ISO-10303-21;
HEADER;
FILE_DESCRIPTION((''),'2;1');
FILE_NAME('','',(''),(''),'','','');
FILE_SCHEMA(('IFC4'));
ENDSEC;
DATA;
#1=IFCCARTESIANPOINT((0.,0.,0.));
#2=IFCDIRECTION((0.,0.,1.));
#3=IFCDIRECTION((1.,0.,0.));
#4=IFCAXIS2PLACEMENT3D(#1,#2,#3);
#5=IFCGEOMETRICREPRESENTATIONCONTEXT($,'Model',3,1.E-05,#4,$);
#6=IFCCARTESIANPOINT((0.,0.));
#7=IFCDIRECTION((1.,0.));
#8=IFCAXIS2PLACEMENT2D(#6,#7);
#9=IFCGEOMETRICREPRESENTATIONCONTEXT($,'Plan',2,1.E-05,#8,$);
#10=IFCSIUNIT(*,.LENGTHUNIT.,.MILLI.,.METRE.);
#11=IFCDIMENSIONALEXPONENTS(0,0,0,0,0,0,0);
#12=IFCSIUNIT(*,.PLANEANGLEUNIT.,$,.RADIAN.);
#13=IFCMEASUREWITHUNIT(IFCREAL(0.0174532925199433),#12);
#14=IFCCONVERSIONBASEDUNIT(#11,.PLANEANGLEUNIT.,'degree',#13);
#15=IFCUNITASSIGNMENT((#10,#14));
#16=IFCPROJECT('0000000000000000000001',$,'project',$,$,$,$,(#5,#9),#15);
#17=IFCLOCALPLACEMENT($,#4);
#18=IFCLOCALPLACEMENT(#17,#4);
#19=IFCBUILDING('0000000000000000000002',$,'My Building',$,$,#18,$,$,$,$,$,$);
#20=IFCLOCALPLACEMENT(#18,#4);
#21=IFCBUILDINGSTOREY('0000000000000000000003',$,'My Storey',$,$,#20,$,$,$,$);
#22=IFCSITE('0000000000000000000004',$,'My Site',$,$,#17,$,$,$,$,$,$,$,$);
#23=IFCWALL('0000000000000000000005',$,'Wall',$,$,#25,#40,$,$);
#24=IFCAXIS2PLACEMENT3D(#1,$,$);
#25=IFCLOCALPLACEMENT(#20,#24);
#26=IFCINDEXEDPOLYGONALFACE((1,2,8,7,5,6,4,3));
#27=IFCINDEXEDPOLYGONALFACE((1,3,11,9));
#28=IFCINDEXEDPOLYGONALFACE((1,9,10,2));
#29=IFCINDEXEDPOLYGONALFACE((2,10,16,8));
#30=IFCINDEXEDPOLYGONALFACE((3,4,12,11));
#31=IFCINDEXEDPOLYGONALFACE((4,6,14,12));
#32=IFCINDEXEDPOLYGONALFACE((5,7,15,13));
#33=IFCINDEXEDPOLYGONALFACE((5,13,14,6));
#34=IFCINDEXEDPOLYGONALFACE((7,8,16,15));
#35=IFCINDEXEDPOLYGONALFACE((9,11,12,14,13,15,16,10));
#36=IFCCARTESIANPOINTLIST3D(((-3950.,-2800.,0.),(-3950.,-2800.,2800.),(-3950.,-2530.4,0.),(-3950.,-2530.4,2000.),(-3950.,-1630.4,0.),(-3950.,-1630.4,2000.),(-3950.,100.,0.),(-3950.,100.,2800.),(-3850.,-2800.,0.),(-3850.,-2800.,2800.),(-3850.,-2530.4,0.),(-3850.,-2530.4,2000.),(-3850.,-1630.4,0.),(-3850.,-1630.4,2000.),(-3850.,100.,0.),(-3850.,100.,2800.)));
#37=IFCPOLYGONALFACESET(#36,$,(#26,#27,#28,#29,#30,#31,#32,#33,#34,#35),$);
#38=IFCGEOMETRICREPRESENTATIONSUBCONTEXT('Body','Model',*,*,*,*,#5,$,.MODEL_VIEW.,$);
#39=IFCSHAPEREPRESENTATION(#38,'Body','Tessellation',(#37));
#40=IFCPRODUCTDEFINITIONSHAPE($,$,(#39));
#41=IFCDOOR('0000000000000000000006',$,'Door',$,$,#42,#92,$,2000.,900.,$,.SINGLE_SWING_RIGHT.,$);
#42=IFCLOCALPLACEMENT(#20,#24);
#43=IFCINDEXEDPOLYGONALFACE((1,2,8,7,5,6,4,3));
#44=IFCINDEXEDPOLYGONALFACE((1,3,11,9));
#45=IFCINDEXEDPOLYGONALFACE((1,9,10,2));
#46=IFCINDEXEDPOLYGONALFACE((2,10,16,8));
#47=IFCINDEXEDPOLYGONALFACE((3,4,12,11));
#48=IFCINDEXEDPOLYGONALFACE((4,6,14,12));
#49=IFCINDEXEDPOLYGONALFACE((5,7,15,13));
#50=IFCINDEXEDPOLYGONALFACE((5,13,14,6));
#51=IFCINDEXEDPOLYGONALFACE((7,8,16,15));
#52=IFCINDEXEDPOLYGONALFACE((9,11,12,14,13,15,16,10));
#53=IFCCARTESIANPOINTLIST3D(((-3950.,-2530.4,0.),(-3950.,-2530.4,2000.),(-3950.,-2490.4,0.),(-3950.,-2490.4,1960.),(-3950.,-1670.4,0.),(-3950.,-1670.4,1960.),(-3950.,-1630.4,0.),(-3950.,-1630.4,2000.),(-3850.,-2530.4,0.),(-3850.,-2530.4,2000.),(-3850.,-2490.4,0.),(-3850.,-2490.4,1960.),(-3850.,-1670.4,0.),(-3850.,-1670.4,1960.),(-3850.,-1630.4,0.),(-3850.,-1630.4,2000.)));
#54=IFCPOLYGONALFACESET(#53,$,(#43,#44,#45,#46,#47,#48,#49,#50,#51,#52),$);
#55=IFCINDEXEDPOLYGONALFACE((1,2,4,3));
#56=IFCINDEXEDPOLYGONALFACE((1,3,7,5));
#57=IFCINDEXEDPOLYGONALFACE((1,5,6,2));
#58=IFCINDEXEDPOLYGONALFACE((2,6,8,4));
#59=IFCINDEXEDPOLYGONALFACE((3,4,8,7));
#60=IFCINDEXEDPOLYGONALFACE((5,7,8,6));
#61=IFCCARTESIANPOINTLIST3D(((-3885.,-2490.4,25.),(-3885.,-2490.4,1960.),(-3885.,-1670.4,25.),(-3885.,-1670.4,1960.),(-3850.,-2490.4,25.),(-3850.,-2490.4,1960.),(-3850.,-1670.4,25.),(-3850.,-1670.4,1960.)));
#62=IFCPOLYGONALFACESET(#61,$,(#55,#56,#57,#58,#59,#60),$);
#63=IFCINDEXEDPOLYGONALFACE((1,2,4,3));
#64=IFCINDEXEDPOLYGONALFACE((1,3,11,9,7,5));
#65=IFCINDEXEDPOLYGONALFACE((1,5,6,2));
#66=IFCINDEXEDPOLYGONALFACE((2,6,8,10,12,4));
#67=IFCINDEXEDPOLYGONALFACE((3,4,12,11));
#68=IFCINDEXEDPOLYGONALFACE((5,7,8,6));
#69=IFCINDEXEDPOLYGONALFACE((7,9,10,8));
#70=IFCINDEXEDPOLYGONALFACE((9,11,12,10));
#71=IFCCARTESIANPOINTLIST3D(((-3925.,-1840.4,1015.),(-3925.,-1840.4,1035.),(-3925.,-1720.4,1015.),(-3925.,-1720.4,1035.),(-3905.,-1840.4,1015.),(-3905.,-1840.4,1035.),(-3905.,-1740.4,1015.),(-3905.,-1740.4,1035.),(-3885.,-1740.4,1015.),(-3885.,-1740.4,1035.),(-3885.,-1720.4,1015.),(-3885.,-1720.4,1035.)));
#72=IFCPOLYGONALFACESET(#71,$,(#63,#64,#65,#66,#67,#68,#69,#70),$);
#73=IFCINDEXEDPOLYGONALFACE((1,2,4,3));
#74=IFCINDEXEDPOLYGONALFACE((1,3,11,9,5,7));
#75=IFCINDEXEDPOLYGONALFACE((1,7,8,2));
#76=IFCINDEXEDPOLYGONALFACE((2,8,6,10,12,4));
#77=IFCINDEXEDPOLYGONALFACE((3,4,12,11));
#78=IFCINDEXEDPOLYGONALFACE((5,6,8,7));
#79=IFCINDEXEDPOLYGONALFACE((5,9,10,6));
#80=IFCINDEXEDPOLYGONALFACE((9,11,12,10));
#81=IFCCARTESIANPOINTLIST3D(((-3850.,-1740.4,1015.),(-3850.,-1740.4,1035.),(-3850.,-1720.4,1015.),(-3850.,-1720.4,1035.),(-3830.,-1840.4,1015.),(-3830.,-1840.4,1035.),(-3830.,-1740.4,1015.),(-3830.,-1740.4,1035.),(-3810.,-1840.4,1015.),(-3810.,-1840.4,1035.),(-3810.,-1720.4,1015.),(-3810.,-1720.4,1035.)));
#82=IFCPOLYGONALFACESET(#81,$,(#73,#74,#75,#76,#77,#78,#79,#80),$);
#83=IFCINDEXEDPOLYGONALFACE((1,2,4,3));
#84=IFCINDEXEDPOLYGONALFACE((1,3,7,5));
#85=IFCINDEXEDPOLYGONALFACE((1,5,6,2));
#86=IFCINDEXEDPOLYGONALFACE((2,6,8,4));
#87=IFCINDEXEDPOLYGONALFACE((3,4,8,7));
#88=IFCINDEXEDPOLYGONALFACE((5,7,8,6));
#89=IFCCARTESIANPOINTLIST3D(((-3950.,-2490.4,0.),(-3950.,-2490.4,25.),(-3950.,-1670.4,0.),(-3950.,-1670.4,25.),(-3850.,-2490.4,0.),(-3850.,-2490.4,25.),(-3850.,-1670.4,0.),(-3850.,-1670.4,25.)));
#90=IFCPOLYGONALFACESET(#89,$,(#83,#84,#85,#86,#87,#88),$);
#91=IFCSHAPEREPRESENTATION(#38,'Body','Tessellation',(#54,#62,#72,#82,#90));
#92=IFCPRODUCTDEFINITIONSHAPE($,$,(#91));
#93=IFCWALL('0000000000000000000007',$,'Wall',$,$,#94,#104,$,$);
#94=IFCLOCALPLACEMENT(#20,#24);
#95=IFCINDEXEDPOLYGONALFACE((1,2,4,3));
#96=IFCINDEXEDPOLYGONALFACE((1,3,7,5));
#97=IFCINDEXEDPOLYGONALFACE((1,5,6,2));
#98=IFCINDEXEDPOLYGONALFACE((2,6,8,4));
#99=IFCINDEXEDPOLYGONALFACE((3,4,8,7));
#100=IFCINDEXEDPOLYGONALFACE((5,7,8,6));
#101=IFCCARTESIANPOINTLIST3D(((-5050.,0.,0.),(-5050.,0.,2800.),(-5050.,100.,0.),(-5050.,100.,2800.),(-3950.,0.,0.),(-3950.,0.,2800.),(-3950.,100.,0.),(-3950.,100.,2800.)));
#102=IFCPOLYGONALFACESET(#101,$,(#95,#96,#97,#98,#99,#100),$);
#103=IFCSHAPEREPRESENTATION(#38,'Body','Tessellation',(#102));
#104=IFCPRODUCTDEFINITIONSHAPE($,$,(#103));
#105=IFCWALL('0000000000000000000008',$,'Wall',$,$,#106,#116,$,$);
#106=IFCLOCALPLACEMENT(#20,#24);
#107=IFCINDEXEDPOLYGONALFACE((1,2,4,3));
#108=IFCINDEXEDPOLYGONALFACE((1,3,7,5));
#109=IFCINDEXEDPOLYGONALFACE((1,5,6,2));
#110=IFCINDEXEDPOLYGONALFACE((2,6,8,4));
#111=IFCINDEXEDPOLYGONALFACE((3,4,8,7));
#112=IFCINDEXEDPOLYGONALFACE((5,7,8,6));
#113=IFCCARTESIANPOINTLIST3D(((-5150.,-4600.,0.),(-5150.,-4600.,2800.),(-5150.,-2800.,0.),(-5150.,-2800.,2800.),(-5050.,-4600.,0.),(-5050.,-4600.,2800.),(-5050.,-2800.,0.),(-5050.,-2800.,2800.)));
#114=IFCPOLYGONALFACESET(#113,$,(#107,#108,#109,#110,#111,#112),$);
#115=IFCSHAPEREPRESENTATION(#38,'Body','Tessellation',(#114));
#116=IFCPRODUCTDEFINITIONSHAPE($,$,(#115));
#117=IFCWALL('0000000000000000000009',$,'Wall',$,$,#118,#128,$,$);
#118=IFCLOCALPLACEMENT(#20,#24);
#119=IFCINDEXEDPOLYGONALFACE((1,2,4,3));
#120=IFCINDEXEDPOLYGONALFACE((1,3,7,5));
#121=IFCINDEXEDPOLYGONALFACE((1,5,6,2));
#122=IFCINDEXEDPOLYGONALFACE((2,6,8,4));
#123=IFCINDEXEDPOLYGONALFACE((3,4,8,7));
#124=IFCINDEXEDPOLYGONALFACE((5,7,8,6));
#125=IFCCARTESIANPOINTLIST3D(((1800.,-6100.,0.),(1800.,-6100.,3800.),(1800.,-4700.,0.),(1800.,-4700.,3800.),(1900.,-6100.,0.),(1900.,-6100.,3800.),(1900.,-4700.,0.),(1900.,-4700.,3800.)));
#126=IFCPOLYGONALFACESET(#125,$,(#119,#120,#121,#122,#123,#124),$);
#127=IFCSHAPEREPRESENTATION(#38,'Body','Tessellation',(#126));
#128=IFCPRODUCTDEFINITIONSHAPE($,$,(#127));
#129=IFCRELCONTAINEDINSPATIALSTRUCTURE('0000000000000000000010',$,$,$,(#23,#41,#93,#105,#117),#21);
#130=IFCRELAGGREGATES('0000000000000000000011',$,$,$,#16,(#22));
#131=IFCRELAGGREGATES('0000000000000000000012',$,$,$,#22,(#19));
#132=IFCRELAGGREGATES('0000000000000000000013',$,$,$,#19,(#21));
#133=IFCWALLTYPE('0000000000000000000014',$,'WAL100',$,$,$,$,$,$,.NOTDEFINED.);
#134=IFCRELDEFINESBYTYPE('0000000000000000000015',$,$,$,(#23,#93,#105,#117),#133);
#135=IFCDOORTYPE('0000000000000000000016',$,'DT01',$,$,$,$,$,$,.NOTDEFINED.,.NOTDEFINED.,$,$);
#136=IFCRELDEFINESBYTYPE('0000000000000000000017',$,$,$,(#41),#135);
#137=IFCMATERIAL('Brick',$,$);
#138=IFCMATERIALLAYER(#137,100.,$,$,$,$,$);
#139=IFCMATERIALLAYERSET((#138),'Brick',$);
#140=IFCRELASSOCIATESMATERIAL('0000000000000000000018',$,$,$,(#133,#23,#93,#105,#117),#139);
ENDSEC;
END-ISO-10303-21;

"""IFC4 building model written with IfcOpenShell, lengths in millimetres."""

from ifc_helpers import new_model, entity, si_unit, converted_unit, frame, origin_with_axes, origin_2d_with_axis, place, context, subcontext, project, spatial, line, indexed_curve, outline, extrude, shape, source, transform, mapped, material, layer, layer_set, layer_usage, type_object, type_shapes, element, fill, save


model = new_model("IFC4")

# Units and contexts
model_context = context("Model", 3, precision=1e-05, world=origin_with_axes())
plan_context = context("Plan", 2, precision=1e-05, world=origin_2d_with_axis())
body_context_1 = subcontext(model_context, "Body", "Model", "MODEL_VIEW")
body_context_2 = subcontext(plan_context, "Body", "Plan", "PLAN_VIEW")
ifc_project = project(units=[si_unit("LENGTHUNIT", "METRE", prefix="MILLI"), converted_unit("PLANEANGLEUNIT", "degree", entity("IfcReal", 0.0174532925199433), si_unit("PLANEANGLEUNIT", "RADIAN"), dimensions=[0, 0, 0, 0, 0, 0, 0])], contexts=[model_context, plan_context])

# Site, building, storey
site_placement = place(None, origin_with_axes())
site = spatial("IfcSite", under=ifc_project, at=site_placement, Name="My Site")
building_placement = place(site_placement, origin_with_axes())
building = spatial("IfcBuilding", under=site, at=building_placement, Name="My Building")
storey_placement = place(building_placement, origin_with_axes())
storey = spatial("IfcBuildingStorey", under=building, at=storey_placement, Name="My Storey")

# Shared definitions
ifc_material = material(Name="Brick")
ifc_layer_1 = layer(ifc_material, 100.0)
ifc_layer_set_1 = layer_set([ifc_layer_1], Name="Brick")
wall_type = type_object("IfcWallType", Name="WAL100", PredefinedType="NOTDEFINED", material=ifc_layer_set_1)

# Wall, opening, door
ifc_layer_usage_1 = layer_usage(ifc_layer_set_1, "AXIS2", "POSITIVE", 0.0)
wall_1_placement = place(storey_placement, frame((-3850.0, -2800.0, 0.0), z_axis=(0.0, 0.0, 1.0), x_axis=(0.0, 1.0, 0.0)))
wall_1 = element("IfcWall", 1, at=wall_1_placement, inside=storey, type_object=wall_type, material=ifc_layer_usage_1, Name="Wall", context=body_context_1, shape_type="SweptSolid", body=[
    extrude(outline(indexed_curve([(0.0, 0.0), (0.0, 100.0), (2900.0, 100.0), (2900.0, 0.0), (0.0, 0.0)], self_intersect=False)), origin_with_axes(), (0.0, 0.0, 1.0), 2800.0),
])
shared_shape_1 = source(origin_with_axes(), body_context_1, "Body", "SweptSolid", [
    extrude(outline(indexed_curve([(0.0, 0.0), (900.0, 0.0), (900.0, 2000.0), (0.0, 2000.0)], segments=[line(1, 2, 3, 4, 1)])), frame((0.0, -100.0, 0.0), z_axis=(0.0, -1.0, 0.0), x_axis=(1.0, 0.0, 0.0)), (0.0, 0.0, -1.0), 300.0),
])
opening_1_placement = place(wall_1_placement, frame((1169.6, 100.0, 0.0), z_axis=(0.0, 0.0, 1.0), x_axis=(-1.0, 0.0, 0.0)))
opening_1 = element("IfcOpeningElement", 2, at=opening_1_placement, cuts=wall_1, PredefinedType="OPENING", context=body_context_1, shape_type="MappedRepresentation", body=[
    mapped(shared_shape_1, transform((0.0, 0.0, 0.0), x_axis=(1.0, 0.0, 0.0), y_axis=(0.0, 1.0, 0.0), z_axis=(0.0, 0.0, 1.0), scale=1.0)),
])
door_type_1 = type_object("IfcDoorType", Name="DT01", OperationType="NOTDEFINED", PredefinedType="NOTDEFINED")
shared_shape_2 = source(origin_with_axes(), body_context_1, "Body", "SweptSolid", [
    extrude(outline(indexed_curve([(0.0, 0.0), (0.0, 2000.0), (900.0, 2000.0), (900.0, 0.0), (860.0, 0.0), (860.0, 1960.0), (40.0, 1960.0), (40.0, 0.0)], segments=[line(1, 2, 3, 4, 5, 6, 7, 8, 1)])), frame((0.0, 0.0, 0.0), z_axis=(0.0, -1.0, 0.0), x_axis=(1.0, 0.0, 0.0)), (0.0, 0.0, -1.0), 100.0),
    extrude(outline(indexed_curve([(0.0, 0.0), (820.0, 0.0), (820.0, 35.0), (0.0, 35.0)], segments=[line(1, 2, 3, 4, 1)])), frame((40.0, 65.0, 25.0), z_axis=(0.0, 0.0, 1.0), x_axis=(1.0, 0.0, 0.0)), (0.0, 0.0, 1.0), 1935.0),
    extrude(outline(indexed_curve([(0.0, 0.0), (0.0, -40.0), (120.0, -40.0), (120.0, -20.0), (20.0, -20.0), (20.0, 0.0)], segments=[line(1, 2, 3, 4, 5, 6, 1)])), frame((90.0, 65.0, 1015.0), z_axis=(0.0, 0.0, 1.0), x_axis=(1.0, 0.0, 0.0)), (0.0, 0.0, 1.0), 20.0),
    extrude(outline(indexed_curve([(0.0, 0.0), (0.0, 40.0), (120.0, 40.0), (120.0, 20.0), (20.0, 20.0), (20.0, 0.0)], segments=[line(1, 2, 3, 4, 5, 6, 1)])), frame((90.0, 100.0, 1015.0), z_axis=(0.0, 0.0, 1.0), x_axis=(1.0, 0.0, 0.0)), (0.0, 0.0, 1.0), 20.0),
    extrude(outline(indexed_curve([(0.0, 0.0), (820.0, 0.0), (820.0, 100.0), (0.0, 100.0)], segments=[line(1, 2, 3, 4, 1)])), frame((40.0, 0.0, 0.0), z_axis=(0.0, 0.0, 1.0), x_axis=(1.0, 0.0, 0.0)), (0.0, 0.0, 1.0), 25.0),
])
shared_shape_3 = source(origin_with_axes(), body_context_2, "Body", "Curve2D", [
    entity("IfcIndexedPolyCurve", entity("IfcCartesianPointList2D", [[0.0, 0.0], [40.0, 0.0], [40.0, 100.0], [0.0, 100.0]]), [entity("IfcLineIndex", [1, 2, 3, 4, 1])]),
    entity("IfcIndexedPolyCurve", entity("IfcCartesianPointList2D", [[900.0, 0.0], [860.0, 0.0], [860.0, 100.0], [900.0, 100.0]]), [entity("IfcLineIndex", [1, 2, 3, 4, 1])]),
    entity("IfcTrimmedCurve", entity("IfcEllipse", entity("IfcAxis2Placement2D", entity("IfcCartesianPoint", [825.0, 100.0]), entity("IfcDirection", [1.0, 0.0])), 785.0, 820.0), [entity("IfcCartesianPoint", [825.0, 920.0])], [entity("IfcCartesianPoint", [40.0, 100.0])], True, "CARTESIAN"),
    entity("IfcIndexedPolyCurve", entity("IfcCartesianPointList2D", [[860.0, 100.0], [825.0, 100.0], [825.0, 920.0], [860.0, 920.0]]), [entity("IfcLineIndex", [1, 2, 3, 4, 1])]),
])
type_shapes(door_type_1, [shared_shape_2, shared_shape_3])
door_1_placement = place(opening_1_placement, frame((0.0, 0.0, 0.0), z_axis=(0.0, 0.0, 1.0), x_axis=(1.0, 0.0, 0.0)))
door_1 = element("IfcDoor", 3, at=door_1_placement, inside=storey, type_object=door_type_1, Name="Door", OperationType="SINGLE_SWING_RIGHT", OverallHeight=2000.0, OverallWidth=900.0, shapes=[
    shape(body_context_1, "Body", "MappedRepresentation", [mapped(shared_shape_2, transform((0.0, 0.0, 0.0), x_axis=(1.0, 0.0, 0.0), y_axis=(0.0, 1.0, 0.0), z_axis=(0.0, 0.0, 1.0), scale=1.0))]),
    shape(body_context_2, "Body", "MappedRepresentation", [mapped(shared_shape_3, transform((0.0, 0.0, 0.0), x_axis=(1.0, 0.0, 0.0), y_axis=(0.0, 1.0, 0.0), z_axis=(0.0, 0.0, 1.0), scale=1.0))]),
])
fill(opening_1, door_1)

# Walls
ifc_layer_usage_2 = layer_usage(ifc_layer_set_1, "AXIS2", "POSITIVE", 0.0)
wall_2_placement = place(storey_placement, frame((-3950.0, 100.0, 0.0), z_axis=(0.0, 0.0, 1.0), x_axis=(-1.0, 0.0, 0.0)))
element("IfcWall", 4, at=wall_2_placement, inside=storey, type_object=wall_type, material=ifc_layer_usage_2, Name="Wall", context=body_context_1, shape_type="SweptSolid", body=[
    extrude(outline(indexed_curve([(0.0, 0.0), (0.0, 100.0), (1100.0, 100.0), (1100.0, 0.0), (0.0, 0.0)], self_intersect=False)), origin_with_axes(), (0.0, 0.0, 1.0), 2800.0),
])
ifc_layer_usage_3 = layer_usage(ifc_layer_set_1, "AXIS2", "POSITIVE", 0.0)
wall_3_placement = place(storey_placement, frame((-5050.0, -4600.0, 0.0), z_axis=(0.0, 0.0, 1.0), x_axis=(0.000004, 1.0, 0.0)))
element("IfcWall", 5, at=wall_3_placement, inside=storey, type_object=wall_type, material=ifc_layer_usage_3, Name="Wall", context=body_context_1, shape_type="SweptSolid", body=[
    extrude(outline(indexed_curve([(0.0, 0.0), (0.0, 100.0), (1800.0, 100.0), (1800.0, 0.0), (0.0, 0.0)], self_intersect=False)), origin_with_axes(), (0.0, 0.0, 1.0), 2800.0),
])
ifc_layer_usage_4 = layer_usage(ifc_layer_set_1, "AXIS2", "POSITIVE", 0.0)
wall_4_placement = place(storey_placement, frame((1900.0, -6100.0, 0.0), z_axis=(0.0, 0.0, 1.0), x_axis=(0.000002, 1.0, 0.0)))
element("IfcWall", 6, at=wall_4_placement, inside=storey, type_object=wall_type, material=ifc_layer_usage_4, Name="Wall", context=body_context_1, shape_type="SweptSolid", body=[
    extrude(outline(indexed_curve([(0.0, 0.0), (0.0, 100.0), (1400.0, 100.0), (1400.0, 0.0), (0.0, 0.0)], self_intersect=False)), origin_with_axes(), (0.0, 0.0, 1.0), 3800.0),
])

save(model, "model.ifc")
